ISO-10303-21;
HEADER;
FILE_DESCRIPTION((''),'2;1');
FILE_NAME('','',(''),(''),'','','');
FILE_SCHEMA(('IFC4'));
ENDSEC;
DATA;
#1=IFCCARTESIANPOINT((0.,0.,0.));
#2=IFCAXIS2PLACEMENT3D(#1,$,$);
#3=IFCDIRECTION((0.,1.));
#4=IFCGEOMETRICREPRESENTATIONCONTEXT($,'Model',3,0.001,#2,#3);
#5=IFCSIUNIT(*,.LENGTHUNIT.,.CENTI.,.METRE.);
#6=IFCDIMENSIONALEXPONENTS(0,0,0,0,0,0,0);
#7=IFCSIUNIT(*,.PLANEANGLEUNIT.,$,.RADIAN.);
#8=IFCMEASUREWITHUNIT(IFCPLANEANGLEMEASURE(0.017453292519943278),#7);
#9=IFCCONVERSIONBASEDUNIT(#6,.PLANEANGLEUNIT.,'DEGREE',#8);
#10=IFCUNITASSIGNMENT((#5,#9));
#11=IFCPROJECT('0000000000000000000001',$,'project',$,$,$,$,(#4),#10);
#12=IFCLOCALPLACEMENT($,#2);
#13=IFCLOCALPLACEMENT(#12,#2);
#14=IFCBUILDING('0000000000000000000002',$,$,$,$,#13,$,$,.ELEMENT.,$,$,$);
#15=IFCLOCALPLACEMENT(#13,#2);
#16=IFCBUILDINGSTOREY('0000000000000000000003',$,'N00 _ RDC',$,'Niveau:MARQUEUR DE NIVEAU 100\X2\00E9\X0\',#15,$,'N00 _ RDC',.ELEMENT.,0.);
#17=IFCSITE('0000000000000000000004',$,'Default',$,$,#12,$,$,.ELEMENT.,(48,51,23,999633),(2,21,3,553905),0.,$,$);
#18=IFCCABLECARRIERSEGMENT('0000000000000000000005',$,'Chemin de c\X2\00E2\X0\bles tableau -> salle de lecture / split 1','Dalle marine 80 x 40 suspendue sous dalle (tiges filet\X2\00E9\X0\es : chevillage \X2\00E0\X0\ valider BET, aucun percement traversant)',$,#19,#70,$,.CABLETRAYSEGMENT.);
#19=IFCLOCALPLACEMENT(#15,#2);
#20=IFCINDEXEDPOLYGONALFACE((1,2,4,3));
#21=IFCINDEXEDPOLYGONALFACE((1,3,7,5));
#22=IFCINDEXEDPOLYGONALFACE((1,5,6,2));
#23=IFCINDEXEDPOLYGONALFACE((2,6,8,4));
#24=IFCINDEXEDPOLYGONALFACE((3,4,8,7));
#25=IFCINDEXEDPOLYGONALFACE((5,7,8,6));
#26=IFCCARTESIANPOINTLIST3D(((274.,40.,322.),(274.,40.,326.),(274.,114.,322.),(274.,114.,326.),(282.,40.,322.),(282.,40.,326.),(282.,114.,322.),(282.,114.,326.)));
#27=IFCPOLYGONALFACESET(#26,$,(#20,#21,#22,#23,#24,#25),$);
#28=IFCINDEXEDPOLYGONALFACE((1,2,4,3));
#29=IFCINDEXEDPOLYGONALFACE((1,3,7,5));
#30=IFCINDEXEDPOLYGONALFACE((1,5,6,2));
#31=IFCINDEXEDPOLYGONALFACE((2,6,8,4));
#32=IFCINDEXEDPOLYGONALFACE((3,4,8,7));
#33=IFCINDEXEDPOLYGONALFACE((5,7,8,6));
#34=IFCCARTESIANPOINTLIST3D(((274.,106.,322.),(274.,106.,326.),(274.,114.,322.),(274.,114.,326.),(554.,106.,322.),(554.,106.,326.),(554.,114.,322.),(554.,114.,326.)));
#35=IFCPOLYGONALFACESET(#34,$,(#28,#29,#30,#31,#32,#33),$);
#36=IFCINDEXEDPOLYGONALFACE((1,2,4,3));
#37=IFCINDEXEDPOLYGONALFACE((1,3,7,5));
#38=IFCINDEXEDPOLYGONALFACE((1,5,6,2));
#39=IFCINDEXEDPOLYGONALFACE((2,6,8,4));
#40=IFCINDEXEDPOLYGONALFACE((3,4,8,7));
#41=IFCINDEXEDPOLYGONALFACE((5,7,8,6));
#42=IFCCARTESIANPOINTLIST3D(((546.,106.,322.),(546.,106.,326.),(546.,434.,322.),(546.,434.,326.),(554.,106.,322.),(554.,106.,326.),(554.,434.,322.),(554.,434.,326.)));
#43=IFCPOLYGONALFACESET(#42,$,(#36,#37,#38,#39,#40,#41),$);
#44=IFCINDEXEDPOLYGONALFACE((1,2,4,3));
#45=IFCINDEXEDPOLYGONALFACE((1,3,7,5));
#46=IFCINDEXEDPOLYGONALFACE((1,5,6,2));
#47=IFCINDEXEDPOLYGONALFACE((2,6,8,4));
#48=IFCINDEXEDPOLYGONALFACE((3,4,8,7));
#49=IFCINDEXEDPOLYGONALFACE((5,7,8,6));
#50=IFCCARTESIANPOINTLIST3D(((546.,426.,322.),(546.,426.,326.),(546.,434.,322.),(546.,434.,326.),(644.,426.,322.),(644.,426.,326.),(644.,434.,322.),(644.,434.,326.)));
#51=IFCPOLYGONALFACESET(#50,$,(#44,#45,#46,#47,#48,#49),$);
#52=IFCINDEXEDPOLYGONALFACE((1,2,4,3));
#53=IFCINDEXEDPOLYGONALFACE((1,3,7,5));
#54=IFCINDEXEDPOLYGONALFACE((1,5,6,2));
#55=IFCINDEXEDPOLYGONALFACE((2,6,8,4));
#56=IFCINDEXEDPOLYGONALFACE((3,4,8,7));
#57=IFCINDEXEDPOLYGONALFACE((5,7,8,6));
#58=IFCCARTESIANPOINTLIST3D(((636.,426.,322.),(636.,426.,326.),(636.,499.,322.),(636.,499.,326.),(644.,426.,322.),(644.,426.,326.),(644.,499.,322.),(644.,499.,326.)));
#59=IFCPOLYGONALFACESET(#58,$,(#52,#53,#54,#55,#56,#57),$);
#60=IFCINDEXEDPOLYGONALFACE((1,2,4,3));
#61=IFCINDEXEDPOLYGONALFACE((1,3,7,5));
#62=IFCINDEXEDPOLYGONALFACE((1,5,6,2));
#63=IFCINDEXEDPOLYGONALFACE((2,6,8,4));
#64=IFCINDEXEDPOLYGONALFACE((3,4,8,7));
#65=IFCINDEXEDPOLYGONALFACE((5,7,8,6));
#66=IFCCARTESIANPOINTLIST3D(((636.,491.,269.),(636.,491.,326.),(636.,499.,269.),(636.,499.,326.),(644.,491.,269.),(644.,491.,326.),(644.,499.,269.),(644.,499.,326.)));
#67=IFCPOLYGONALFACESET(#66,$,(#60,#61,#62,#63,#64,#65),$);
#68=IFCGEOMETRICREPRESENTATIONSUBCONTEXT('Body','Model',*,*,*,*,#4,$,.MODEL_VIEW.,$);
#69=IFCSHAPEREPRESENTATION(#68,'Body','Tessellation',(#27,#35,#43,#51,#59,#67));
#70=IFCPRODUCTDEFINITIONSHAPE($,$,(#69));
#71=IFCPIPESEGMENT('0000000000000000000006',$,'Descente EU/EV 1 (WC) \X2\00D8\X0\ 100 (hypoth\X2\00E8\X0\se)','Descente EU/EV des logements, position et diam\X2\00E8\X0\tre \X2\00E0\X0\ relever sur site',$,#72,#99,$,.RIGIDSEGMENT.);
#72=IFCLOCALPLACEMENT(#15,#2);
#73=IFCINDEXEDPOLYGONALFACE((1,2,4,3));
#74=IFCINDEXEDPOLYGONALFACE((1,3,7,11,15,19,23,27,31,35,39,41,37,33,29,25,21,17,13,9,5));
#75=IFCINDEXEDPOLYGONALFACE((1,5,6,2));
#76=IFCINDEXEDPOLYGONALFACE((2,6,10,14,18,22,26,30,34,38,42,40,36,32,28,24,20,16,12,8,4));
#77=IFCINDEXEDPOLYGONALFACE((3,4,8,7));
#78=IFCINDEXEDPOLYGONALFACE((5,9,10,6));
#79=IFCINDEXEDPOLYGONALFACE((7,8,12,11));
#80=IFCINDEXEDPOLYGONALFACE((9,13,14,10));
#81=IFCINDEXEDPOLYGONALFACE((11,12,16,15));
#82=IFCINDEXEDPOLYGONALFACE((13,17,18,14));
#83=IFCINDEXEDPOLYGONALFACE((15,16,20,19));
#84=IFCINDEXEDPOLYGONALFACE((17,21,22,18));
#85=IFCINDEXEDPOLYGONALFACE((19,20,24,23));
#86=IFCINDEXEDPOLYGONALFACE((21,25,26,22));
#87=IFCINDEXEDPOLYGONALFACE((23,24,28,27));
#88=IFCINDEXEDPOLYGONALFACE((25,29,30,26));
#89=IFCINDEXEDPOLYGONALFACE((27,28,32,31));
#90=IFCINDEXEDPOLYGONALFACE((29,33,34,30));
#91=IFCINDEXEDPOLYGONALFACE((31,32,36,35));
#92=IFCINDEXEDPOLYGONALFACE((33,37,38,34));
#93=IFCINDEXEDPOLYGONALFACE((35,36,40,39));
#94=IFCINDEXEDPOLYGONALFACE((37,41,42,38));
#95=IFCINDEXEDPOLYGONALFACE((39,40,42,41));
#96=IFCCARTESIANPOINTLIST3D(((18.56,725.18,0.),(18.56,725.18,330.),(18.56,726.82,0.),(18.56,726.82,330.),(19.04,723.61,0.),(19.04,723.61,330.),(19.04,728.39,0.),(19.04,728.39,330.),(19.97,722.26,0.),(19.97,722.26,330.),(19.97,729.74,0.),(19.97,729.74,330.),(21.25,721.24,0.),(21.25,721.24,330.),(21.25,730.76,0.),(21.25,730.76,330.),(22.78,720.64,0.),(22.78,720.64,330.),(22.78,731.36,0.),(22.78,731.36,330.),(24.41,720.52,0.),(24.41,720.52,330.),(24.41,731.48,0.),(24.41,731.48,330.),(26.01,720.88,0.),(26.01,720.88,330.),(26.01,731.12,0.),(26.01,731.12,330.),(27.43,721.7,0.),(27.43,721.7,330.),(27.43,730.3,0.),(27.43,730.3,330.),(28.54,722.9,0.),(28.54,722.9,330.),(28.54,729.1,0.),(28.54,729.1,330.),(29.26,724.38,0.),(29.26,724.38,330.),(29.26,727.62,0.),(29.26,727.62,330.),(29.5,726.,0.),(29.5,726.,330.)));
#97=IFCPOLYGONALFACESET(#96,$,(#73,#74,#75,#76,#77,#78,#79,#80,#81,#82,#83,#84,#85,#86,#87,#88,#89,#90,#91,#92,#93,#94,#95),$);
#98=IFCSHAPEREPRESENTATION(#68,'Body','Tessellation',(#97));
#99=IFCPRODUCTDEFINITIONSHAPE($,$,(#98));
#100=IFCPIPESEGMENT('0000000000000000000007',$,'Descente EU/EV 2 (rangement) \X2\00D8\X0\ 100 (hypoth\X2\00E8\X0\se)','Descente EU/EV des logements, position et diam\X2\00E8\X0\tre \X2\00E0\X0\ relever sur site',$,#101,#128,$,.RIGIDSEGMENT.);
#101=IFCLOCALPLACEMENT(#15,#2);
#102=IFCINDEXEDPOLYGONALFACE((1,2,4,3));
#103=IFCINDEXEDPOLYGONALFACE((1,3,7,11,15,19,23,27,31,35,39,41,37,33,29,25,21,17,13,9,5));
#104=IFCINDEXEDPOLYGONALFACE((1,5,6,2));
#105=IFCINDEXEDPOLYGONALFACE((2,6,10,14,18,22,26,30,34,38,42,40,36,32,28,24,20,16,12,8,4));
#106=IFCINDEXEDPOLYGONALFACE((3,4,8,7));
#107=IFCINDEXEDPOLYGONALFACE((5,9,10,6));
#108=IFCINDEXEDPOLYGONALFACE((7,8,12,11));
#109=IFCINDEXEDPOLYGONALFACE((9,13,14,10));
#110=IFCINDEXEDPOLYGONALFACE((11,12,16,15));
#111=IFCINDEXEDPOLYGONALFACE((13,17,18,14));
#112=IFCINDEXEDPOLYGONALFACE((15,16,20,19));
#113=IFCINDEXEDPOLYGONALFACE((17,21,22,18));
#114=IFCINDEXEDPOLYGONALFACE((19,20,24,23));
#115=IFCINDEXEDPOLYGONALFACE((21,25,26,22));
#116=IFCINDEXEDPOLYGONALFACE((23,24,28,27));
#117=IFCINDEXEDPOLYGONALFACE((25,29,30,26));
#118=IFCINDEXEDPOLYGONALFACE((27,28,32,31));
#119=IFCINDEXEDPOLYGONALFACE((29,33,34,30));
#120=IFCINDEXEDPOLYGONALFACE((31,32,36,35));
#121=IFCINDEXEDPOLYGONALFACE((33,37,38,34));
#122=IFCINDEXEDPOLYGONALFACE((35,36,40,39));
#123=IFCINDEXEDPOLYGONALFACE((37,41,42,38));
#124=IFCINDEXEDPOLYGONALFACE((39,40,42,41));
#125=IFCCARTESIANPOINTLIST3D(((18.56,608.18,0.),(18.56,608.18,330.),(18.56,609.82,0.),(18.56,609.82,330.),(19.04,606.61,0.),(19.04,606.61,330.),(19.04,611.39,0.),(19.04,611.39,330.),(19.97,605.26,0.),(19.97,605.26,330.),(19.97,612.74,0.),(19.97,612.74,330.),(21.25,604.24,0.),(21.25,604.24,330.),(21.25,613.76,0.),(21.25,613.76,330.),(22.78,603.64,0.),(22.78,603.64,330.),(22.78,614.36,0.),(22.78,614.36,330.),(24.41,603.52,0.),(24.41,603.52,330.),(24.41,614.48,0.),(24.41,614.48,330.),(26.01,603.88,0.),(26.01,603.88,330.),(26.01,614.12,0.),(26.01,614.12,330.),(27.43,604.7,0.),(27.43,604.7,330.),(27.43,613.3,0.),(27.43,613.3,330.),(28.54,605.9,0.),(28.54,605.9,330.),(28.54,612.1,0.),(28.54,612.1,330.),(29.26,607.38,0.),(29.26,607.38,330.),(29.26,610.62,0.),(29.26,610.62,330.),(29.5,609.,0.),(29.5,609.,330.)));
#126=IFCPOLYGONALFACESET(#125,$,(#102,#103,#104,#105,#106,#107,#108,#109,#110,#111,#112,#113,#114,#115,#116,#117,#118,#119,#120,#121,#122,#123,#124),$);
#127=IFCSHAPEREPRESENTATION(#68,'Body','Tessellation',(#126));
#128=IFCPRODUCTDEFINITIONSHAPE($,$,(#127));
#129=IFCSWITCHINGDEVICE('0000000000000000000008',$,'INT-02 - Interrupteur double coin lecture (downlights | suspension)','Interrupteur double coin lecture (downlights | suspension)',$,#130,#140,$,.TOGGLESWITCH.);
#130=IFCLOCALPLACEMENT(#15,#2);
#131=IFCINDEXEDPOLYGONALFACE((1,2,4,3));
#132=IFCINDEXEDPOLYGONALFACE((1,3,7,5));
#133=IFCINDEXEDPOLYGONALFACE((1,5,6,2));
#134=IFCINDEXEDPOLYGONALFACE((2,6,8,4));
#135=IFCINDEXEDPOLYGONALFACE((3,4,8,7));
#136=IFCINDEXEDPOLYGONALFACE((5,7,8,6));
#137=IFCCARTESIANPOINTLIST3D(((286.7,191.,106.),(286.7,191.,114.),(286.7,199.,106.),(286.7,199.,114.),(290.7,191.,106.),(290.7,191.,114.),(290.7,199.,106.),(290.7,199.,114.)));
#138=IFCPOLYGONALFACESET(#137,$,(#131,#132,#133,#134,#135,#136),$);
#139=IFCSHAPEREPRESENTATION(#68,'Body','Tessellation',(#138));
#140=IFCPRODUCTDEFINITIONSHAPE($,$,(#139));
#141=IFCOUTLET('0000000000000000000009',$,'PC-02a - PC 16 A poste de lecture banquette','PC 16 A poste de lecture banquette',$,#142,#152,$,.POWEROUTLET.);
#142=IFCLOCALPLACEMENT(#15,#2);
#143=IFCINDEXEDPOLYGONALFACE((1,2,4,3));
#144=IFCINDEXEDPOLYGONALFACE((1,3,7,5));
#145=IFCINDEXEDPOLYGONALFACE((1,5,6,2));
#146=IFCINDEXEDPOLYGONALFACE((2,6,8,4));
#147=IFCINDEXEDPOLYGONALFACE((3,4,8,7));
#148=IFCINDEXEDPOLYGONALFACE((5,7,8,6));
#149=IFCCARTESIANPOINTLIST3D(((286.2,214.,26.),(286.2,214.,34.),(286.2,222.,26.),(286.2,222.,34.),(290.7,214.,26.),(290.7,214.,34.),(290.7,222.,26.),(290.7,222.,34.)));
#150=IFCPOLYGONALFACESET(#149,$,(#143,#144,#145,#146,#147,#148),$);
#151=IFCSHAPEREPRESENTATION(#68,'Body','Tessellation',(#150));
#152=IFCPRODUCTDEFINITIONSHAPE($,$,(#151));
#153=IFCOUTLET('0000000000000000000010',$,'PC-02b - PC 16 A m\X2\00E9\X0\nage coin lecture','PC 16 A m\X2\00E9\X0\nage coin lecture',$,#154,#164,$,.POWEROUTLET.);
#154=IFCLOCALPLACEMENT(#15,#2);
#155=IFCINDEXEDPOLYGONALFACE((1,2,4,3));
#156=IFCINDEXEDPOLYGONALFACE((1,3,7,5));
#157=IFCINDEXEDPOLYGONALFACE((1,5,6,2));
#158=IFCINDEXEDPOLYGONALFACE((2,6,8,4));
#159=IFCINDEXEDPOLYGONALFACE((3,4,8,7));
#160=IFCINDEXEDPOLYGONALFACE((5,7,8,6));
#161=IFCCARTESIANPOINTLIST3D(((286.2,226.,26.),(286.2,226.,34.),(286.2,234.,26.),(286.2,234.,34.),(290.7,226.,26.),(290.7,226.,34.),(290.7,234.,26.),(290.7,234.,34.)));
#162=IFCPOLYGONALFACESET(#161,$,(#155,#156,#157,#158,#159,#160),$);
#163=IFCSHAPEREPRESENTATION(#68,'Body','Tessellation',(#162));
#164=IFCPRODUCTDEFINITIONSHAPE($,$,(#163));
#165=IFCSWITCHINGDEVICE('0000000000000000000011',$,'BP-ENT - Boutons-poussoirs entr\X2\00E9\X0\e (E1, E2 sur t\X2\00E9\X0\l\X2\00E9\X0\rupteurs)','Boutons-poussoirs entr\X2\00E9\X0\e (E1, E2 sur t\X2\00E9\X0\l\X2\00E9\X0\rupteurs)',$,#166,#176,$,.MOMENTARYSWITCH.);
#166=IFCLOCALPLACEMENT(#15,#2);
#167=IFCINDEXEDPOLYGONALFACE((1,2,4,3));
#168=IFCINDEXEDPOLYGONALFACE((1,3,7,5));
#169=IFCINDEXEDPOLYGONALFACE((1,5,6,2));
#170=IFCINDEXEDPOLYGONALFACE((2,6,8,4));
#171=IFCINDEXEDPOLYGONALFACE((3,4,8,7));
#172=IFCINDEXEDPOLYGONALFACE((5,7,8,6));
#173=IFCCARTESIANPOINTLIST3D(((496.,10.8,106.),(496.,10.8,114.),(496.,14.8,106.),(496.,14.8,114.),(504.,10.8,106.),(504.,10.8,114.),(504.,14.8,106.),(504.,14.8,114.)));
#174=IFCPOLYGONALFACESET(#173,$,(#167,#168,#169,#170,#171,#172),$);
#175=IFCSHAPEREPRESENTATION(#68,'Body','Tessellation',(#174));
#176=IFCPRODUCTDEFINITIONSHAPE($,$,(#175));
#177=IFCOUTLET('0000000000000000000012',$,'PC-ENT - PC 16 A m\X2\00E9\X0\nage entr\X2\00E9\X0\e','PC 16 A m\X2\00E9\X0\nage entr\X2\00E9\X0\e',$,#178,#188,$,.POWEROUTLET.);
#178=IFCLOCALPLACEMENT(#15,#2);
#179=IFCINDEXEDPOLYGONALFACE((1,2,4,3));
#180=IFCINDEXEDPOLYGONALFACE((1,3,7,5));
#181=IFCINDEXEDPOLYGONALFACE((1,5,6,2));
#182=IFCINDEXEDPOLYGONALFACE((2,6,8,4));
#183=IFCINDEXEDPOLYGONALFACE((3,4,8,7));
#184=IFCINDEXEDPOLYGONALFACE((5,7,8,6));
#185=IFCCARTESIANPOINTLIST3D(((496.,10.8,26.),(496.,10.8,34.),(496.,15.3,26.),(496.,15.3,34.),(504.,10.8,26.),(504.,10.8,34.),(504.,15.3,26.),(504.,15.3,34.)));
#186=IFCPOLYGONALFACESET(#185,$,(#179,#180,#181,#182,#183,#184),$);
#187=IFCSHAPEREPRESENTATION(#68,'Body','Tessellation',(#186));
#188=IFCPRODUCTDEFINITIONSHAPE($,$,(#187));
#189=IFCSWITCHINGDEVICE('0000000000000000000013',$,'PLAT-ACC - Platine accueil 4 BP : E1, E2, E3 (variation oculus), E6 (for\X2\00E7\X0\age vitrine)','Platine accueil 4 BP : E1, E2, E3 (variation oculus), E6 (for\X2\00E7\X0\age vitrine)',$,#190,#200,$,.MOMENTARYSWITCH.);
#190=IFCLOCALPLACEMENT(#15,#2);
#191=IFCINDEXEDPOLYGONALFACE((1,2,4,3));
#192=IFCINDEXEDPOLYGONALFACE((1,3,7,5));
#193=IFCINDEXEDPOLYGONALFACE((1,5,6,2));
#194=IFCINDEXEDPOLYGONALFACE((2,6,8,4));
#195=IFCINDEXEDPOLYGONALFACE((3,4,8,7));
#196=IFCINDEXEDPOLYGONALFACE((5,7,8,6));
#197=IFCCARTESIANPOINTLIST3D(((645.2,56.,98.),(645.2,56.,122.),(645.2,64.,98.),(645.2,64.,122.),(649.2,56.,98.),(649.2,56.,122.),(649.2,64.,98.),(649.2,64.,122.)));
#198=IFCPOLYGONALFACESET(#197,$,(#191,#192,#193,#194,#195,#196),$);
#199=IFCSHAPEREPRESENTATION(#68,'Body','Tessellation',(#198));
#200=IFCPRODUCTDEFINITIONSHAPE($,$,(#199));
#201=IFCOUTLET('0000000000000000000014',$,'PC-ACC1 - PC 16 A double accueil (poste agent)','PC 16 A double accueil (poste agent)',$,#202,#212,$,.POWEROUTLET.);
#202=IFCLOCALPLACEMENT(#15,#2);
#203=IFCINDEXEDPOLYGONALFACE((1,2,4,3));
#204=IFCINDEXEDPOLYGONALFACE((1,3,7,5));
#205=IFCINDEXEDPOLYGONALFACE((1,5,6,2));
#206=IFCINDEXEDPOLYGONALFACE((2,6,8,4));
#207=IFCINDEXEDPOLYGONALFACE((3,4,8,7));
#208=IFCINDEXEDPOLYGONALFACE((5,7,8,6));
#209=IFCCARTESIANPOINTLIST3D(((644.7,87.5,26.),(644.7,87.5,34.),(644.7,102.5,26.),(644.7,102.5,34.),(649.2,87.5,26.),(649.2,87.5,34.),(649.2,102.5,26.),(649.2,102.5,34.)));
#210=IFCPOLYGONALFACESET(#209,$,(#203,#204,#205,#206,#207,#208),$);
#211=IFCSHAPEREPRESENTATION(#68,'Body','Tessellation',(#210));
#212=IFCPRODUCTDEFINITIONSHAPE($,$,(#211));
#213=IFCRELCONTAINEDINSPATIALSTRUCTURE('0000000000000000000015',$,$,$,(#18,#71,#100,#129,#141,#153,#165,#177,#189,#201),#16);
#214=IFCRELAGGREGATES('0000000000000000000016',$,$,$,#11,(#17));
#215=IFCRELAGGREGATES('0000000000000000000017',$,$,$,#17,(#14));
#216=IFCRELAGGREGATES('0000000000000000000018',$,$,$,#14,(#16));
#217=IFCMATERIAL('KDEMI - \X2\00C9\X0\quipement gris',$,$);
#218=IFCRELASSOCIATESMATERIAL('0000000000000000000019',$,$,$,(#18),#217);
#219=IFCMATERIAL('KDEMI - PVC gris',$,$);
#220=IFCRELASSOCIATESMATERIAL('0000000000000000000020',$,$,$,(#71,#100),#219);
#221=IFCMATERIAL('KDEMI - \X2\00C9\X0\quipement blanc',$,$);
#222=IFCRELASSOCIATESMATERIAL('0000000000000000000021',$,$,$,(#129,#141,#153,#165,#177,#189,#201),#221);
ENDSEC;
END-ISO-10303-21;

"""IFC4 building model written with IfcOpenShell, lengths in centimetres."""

from ifc_helpers import new_model, entity, si_unit, converted_unit, direction, frame, frame_2d, origin, origin_with_axes, place, context, subcontext, project, spatial, rectangle, circle, extrude, material, element, save


model = new_model("IFC4")

# Units and contexts
model_context = context("Model", 3, precision=0.001, world=origin(), true_north=direction((0.0, 1.0)))
body_context = subcontext(model_context, "Body", "Model", "MODEL_VIEW")
ifc_project = project(units=[si_unit("LENGTHUNIT", "METRE", prefix="CENTI"), converted_unit("PLANEANGLEUNIT", "DEGREE", entity("IfcPlaneAngleMeasure", 0.017453292519943278), si_unit("PLANEANGLEUNIT", "RADIAN"), dimensions=[0, 0, 0, 0, 0, 0, 0])], contexts=[model_context])

# Site, building, storey
site_placement = place(None, origin())
site = spatial("IfcSite", under=ifc_project, at=site_placement, Name="Default", CompositionType="ELEMENT", RefLatitude=(48, 51, 23, 999633), RefLongitude=(2, 21, 3, 553905), RefElevation=0.0)
building_placement = place(site_placement, origin())
building = spatial("IfcBuilding", under=site, at=building_placement, CompositionType="ELEMENT")
storey_placement = place(building_placement, origin())
storey = spatial("IfcBuildingStorey", under=building, at=storey_placement, Name="N00 _ RDC", ObjectType="Niveau:MARQUEUR DE NIVEAU 100é", LongName="N00 _ RDC", CompositionType="ELEMENT", Elevation=0.0)

# Shared definitions
ifc_material_1 = material(Name="KDEMI - Équipement blanc")

# Shared definitions
ifc_material_2 = material(Name="KDEMI - Équipement gris")

# Shared definitions
ifc_material_3 = material(Name="KDEMI - PVC gris")

# Cable carrier segment
cable_carrier_segment_1_placement = place(storey_placement, origin_with_axes())
element("IfcCableCarrierSegment", 1, at=cable_carrier_segment_1_placement, inside=storey, material=ifc_material_2, Name="Chemin de câbles tableau -> salle de lecture / split 1", Description="Dalle marine 80 x 40 suspendue sous dalle (tiges filetées : chevillage à valider BET, aucun percement traversant)", PredefinedType="CABLETRAYSEGMENT", context=body_context, shape_type="SweptSolid", body=[
    extrude(rectangle(XDim=8.0, YDim=74.0, at=frame_2d((278.0, 77.0))), frame((0.0, 0.0, 322.0)), (0.0, 0.0, 1.0), 4.0),
    extrude(rectangle(XDim=280.0, YDim=8.0, at=frame_2d((414.0, 110.0))), frame((0.0, 0.0, 322.0)), (0.0, 0.0, 1.0), 4.0),
    extrude(rectangle(XDim=8.0, YDim=328.0, at=frame_2d((550.0, 270.0))), frame((0.0, 0.0, 322.0)), (0.0, 0.0, 1.0), 4.0),
    extrude(rectangle(XDim=98.0, YDim=8.0, at=frame_2d((595.0, 430.0))), frame((0.0, 0.0, 322.0)), (0.0, 0.0, 1.0), 4.0),
    extrude(rectangle(XDim=8.0, YDim=73.0, at=frame_2d((640.0, 462.5))), frame((0.0, 0.0, 322.0)), (0.0, 0.0, 1.0), 4.0),
    extrude(rectangle(XDim=8.0, YDim=8.0, at=frame_2d((640.0, 495.0))), frame((0.0, 0.0, 269.0)), (0.0, 0.0, 1.0), 57.0),
])

# Pipe segments
pipe_segment_1_placement = place(storey_placement, origin_with_axes())
element("IfcPipeSegment", 2, at=pipe_segment_1_placement, inside=storey, material=ifc_material_3, Name="Descente EU/EV 1 (WC) Ø 100 (hypothèse)", Description="Descente EU/EV des logements, position et diamètre à relever sur site", PredefinedType="RIGIDSEGMENT", context=body_context, shape_type="SweptSolid", body=[
    extrude(circle(Radius=5.5, at=frame_2d((24.0, 726.0))), origin(), (0.0, 0.0, 1.0), 330.0),
])
pipe_segment_2_placement = place(storey_placement, origin_with_axes())
element("IfcPipeSegment", 3, at=pipe_segment_2_placement, inside=storey, material=ifc_material_3, Name="Descente EU/EV 2 (rangement) Ø 100 (hypothèse)", Description="Descente EU/EV des logements, position et diamètre à relever sur site", PredefinedType="RIGIDSEGMENT", context=body_context, shape_type="SweptSolid", body=[
    extrude(circle(Radius=5.5, at=frame_2d((24.0, 609.0))), origin(), (0.0, 0.0, 1.0), 330.0),
])

# Switching device
switching_device_1_placement = place(storey_placement, origin_with_axes())
element("IfcSwitchingDevice", 4, at=switching_device_1_placement, inside=storey, material=ifc_material_1, Name="INT-02 - Interrupteur double coin lecture (downlights | suspension)", Description="Interrupteur double coin lecture (downlights | suspension)", PredefinedType="TOGGLESWITCH", context=body_context, shape_type="SweptSolid", body=[
    extrude(rectangle(XDim=4.0, YDim=8.0, at=frame_2d((288.7, 195.0))), frame((0.0, 0.0, 106.0)), (0.0, 0.0, 1.0), 8.0),
])

# Outlets
outlet_1_placement = place(storey_placement, origin_with_axes())
element("IfcOutlet", 5, at=outlet_1_placement, inside=storey, material=ifc_material_1, Name="PC-02a - PC 16 A poste de lecture banquette", Description="PC 16 A poste de lecture banquette", PredefinedType="POWEROUTLET", context=body_context, shape_type="SweptSolid", body=[
    extrude(rectangle(XDim=4.5, YDim=8.0, at=frame_2d((288.45, 218.0))), frame((0.0, 0.0, 26.0)), (0.0, 0.0, 1.0), 8.0),
])
outlet_2_placement = place(storey_placement, origin_with_axes())
element("IfcOutlet", 6, at=outlet_2_placement, inside=storey, material=ifc_material_1, Name="PC-02b - PC 16 A ménage coin lecture", Description="PC 16 A ménage coin lecture", PredefinedType="POWEROUTLET", context=body_context, shape_type="SweptSolid", body=[
    extrude(rectangle(XDim=4.5, YDim=8.0, at=frame_2d((288.45, 230.0))), frame((0.0, 0.0, 26.0)), (0.0, 0.0, 1.0), 8.0),
])

# Switching device
switching_device_2_placement = place(storey_placement, origin_with_axes())
element("IfcSwitchingDevice", 7, at=switching_device_2_placement, inside=storey, material=ifc_material_1, Name="BP-ENT - Boutons-poussoirs entrée (E1, E2 sur télérupteurs)", Description="Boutons-poussoirs entrée (E1, E2 sur télérupteurs)", PredefinedType="MOMENTARYSWITCH", context=body_context, shape_type="SweptSolid", body=[
    extrude(rectangle(XDim=8.0, YDim=4.0, at=frame_2d((500.0, 12.8))), frame((0.0, 0.0, 106.0)), (0.0, 0.0, 1.0), 8.0),
])

# Outlet
outlet_3_placement = place(storey_placement, origin_with_axes())
element("IfcOutlet", 8, at=outlet_3_placement, inside=storey, material=ifc_material_1, Name="PC-ENT - PC 16 A ménage entrée", Description="PC 16 A ménage entrée", PredefinedType="POWEROUTLET", context=body_context, shape_type="SweptSolid", body=[
    extrude(rectangle(XDim=8.0, YDim=4.5, at=frame_2d((500.0, 13.05))), frame((0.0, 0.0, 26.0)), (0.0, 0.0, 1.0), 8.0),
])

# Switching device
switching_device_3_placement = place(storey_placement, origin_with_axes())
element("IfcSwitchingDevice", 9, at=switching_device_3_placement, inside=storey, material=ifc_material_1, Name="PLAT-ACC - Platine accueil 4 BP : E1, E2, E3 (variation oculus), E6 (forçage vitrine)", Description="Platine accueil 4 BP : E1, E2, E3 (variation oculus), E6 (forçage vitrine)", PredefinedType="MOMENTARYSWITCH", context=body_context, shape_type="SweptSolid", body=[
    extrude(rectangle(XDim=4.0, YDim=8.0, at=frame_2d((647.2, 60.0))), frame((0.0, 0.0, 98.0)), (0.0, 0.0, 1.0), 24.0),
])

# Outlet
outlet_4_placement = place(storey_placement, origin_with_axes())
element("IfcOutlet", 10, at=outlet_4_placement, inside=storey, material=ifc_material_1, Name="PC-ACC1 - PC 16 A double accueil (poste agent)", Description="PC 16 A double accueil (poste agent)", PredefinedType="POWEROUTLET", context=body_context, shape_type="SweptSolid", body=[
    extrude(rectangle(XDim=4.5, YDim=15.0, at=frame_2d((646.95, 95.0))), frame((0.0, 0.0, 26.0)), (0.0, 0.0, 1.0), 8.0),
])

save(model, "model.ifc")
